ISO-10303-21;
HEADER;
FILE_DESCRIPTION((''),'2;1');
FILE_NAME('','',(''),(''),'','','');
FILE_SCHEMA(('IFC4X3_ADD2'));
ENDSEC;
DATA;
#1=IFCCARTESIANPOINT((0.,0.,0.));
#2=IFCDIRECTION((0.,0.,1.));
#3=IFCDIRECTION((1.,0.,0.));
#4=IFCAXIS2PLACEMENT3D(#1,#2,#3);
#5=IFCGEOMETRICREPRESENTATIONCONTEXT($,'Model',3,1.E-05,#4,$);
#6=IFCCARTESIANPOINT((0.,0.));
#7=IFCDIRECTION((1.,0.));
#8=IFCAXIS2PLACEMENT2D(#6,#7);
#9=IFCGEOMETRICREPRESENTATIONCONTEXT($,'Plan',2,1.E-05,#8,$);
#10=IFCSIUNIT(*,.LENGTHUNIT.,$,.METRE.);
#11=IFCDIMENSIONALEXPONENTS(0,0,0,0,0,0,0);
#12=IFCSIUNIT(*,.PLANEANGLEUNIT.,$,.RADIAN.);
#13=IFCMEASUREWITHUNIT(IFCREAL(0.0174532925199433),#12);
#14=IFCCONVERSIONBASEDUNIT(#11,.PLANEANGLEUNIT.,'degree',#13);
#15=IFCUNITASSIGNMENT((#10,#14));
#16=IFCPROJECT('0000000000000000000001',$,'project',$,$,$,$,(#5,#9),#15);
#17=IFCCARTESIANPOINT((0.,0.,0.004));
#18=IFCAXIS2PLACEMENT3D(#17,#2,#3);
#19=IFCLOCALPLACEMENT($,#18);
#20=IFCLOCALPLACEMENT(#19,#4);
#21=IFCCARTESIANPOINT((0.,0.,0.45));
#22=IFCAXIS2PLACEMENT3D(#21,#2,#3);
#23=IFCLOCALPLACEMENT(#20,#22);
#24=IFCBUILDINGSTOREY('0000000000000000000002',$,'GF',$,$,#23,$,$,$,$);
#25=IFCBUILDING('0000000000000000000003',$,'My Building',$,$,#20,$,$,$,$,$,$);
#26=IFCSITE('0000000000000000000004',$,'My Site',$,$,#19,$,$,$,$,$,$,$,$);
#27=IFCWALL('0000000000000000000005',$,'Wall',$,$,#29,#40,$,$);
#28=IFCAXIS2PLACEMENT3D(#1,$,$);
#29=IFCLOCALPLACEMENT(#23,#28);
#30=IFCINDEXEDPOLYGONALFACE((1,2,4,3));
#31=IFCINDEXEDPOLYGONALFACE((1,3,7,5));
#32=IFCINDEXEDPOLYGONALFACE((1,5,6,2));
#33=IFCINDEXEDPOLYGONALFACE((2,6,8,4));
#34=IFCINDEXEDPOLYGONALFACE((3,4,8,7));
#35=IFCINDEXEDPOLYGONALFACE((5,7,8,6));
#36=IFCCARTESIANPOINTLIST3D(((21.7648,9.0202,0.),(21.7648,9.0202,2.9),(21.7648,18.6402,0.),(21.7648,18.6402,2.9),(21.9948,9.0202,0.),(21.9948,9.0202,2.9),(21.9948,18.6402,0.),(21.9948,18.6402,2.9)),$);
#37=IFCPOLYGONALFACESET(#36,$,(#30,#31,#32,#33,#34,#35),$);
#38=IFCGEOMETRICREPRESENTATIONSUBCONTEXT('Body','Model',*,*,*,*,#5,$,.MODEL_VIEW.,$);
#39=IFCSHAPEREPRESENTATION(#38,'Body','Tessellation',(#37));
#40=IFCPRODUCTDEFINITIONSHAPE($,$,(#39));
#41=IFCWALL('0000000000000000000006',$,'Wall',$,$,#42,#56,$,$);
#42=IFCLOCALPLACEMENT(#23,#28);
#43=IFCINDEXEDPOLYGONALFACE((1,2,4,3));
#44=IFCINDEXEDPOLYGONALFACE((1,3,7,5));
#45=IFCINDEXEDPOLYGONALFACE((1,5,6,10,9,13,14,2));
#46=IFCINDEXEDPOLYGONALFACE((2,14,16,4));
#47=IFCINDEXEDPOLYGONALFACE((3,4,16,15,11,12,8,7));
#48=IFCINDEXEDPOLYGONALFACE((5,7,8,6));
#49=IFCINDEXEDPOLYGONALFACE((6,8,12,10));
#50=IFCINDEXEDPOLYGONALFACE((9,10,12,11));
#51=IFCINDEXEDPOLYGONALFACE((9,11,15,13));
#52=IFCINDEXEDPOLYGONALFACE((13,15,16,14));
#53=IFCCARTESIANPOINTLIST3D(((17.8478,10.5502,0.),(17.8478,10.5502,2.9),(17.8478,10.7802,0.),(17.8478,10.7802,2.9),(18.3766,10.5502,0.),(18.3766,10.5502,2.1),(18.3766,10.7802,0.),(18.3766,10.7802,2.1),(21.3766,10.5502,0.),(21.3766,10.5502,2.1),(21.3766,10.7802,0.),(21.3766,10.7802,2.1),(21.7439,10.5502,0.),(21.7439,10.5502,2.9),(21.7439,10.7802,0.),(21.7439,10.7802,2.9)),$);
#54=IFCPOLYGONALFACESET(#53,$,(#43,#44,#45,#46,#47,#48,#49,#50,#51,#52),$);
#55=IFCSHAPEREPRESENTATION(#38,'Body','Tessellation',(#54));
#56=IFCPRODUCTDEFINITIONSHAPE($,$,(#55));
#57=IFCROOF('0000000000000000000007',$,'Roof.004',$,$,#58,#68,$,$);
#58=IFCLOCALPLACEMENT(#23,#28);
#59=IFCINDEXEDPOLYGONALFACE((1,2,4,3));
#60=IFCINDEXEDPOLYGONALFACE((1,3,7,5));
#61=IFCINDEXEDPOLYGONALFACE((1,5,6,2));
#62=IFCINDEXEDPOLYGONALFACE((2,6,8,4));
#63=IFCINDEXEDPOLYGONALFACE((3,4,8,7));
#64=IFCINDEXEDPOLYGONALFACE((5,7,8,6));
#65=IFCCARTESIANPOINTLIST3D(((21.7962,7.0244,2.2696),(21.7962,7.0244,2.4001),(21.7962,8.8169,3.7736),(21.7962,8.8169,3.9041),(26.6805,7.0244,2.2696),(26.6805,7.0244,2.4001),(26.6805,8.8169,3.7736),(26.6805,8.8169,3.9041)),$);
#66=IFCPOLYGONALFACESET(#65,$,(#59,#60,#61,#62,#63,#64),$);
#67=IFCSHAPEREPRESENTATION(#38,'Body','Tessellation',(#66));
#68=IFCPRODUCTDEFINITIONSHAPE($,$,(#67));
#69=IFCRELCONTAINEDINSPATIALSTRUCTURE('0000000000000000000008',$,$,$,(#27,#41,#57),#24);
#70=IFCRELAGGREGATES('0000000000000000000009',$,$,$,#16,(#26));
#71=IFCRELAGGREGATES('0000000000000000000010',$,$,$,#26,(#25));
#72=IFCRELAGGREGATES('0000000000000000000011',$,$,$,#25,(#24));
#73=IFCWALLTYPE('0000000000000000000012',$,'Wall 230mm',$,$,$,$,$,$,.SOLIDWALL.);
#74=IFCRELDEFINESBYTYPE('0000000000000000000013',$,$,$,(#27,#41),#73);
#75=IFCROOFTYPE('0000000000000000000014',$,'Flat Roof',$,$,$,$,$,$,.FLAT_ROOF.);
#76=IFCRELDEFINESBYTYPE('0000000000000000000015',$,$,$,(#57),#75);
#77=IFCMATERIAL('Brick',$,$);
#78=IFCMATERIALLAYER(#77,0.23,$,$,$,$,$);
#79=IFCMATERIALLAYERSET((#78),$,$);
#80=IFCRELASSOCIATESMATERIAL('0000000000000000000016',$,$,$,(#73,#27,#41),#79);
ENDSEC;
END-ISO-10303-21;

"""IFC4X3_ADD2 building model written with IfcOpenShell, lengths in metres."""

from ifc_helpers import new_model, entity, si_unit, converted_unit, frame, origin_with_axes, origin_2d_with_axis, place, context, subcontext, project, spatial, polyline, line, indexed_curve, outline, extrude, source, transform, mapped, material, layer, layer_set, layer_usage, type_object, element, save


model = new_model("IFC4X3_ADD2")

# Units and contexts
model_context = context("Model", 3, precision=1e-05, world=origin_with_axes())
plan_context = context("Plan", 2, precision=1e-05, world=origin_2d_with_axis())
body_context = subcontext(model_context, "Body", "Model", "MODEL_VIEW")
ifc_project = project(units=[si_unit("LENGTHUNIT", "METRE"), converted_unit("PLANEANGLEUNIT", "degree", entity("IfcReal", 0.0174532925199433), si_unit("PLANEANGLEUNIT", "RADIAN"), dimensions=[0, 0, 0, 0, 0, 0, 0])], contexts=[model_context, plan_context])

# Site, building, storey
site_placement = place(None, frame((0.0, 0.0, 0.004), z_axis=(0.0, 0.0, 1.0), x_axis=(1.0, 0.0, 0.0)))
site = spatial("IfcSite", under=ifc_project, at=site_placement, Name="My Site")
building_placement = place(site_placement, origin_with_axes())
building = spatial("IfcBuilding", under=site, at=building_placement, Name="My Building")
storey_placement = place(building_placement, frame((0.0, 0.0, 0.45), z_axis=(0.0, 0.0, 1.0), x_axis=(1.0, 0.0, 0.0)))
storey = spatial("IfcBuildingStorey", under=building, at=storey_placement, Name="GF")

# Shared definitions
ifc_material_1 = material(Name="Brick")
ifc_layer = layer(ifc_material_1, 0.23)
ifc_layer_set = layer_set([ifc_layer])
wall_type = type_object("IfcWallType", Name="Wall 230mm", PredefinedType="SOLIDWALL", material=ifc_layer_set)
shared_shape = source(origin_with_axes(), body_context, "Body", "SweptSolid", [
    extrude(outline(indexed_curve([(0.0, 0.0), (3.0, 0.0), (3.0, 2.1), (0.0, 2.1)], segments=[line(1, 2, 3, 4, 1)])), frame((0.0, -0.6, 0.0), z_axis=(0.0, -1.0, 0.0), x_axis=(1.0, 0.0, 0.0)), (0.0, 0.0, -1.0), 1.2),
])

# Wall
ifc_layer_usage_1 = layer_usage(ifc_layer_set, "AXIS2", "POSITIVE", 0.0)
wall_1_placement = place(storey_placement, frame((21.9948, 9.0202, 0.0), z_axis=(0.0, 0.0, 1.0), x_axis=(0.000001, 1.0, 0.0)))
element("IfcWall", 1, at=wall_1_placement, inside=storey, type_object=wall_type, material=ifc_layer_usage_1, Name="Wall", context=body_context, shape_type="SweptSolid", body=[
    extrude(outline(indexed_curve([(0.0, 0.0), (0.0, 0.23), (9.62, 0.23), (9.62, 0.0), (0.0, 0.0)], self_intersect=False)), origin_with_axes(), (0.0, 0.0, 1.0), 2.9),
])

# Wall, opening
ifc_layer_usage_2 = layer_usage(ifc_layer_set, "AXIS2", "POSITIVE", 0.0)
wall_2_placement = place(storey_placement, frame((21.7439, 10.7802, 0.0), z_axis=(0.0, 0.0, 1.0), x_axis=(-1.0, 0.0, 0.0)))
wall_2 = element("IfcWall", 2, at=wall_2_placement, inside=storey, type_object=wall_type, material=ifc_layer_usage_2, Name="Wall", context=body_context, shape_type="SweptSolid", body=[
    extrude(outline(indexed_curve([(0.0, 0.0), (0.0, 0.23), (3.8962, 0.23), (3.8962, 0.0), (0.0, 0.0)], self_intersect=False)), origin_with_axes(), (0.0, 0.0, 1.0), 2.9),
])
opening_1_placement = place(wall_2_placement, frame((0.3674, 0.0, 0.0), z_axis=(0.0, 0.0, 1.0), x_axis=(1.0, 0.0, 0.0)))
element("IfcOpeningElement", 3, at=opening_1_placement, cuts=wall_2, PredefinedType="OPENING", context=body_context, shape_type="MappedRepresentation", body=[
    mapped(shared_shape, transform((0.0, 0.0, 0.0), x_axis=(1.0, 0.0, 0.0), y_axis=(0.0, 1.0, 0.0), z_axis=(0.0, 0.0, 1.0), scale=1.0)),
])

# Roof
roof_type = type_object("IfcRoofType", Name="Flat Roof", PredefinedType="FLAT_ROOF")
roof_placement = place(storey_placement, frame((21.7962, 8.0241, 3.1084), z_axis=(0.0, -0.642788, 0.766044), x_axis=(1.0, 0.0, 0.0)))
element("IfcRoof", 4, at=roof_placement, inside=storey, type_object=roof_type, Name="Roof.004", context=body_context, shape_type="SweptSolid", body=[
    extrude(outline(polyline([(-2.4421, -0.0653), (2.4421, -0.0653), (2.4421, 0.0653), (-2.4421, 0.0653), (-2.4421, -0.0653)])), frame((2.4421, 1.0768, 0.05), z_axis=(0.0, 0.766044, -0.642788), x_axis=(1.0, 0.0, 0.0)), (0.0, 0.642788, -0.766044), 2.3398),
])

save(model, "model.ifc")
